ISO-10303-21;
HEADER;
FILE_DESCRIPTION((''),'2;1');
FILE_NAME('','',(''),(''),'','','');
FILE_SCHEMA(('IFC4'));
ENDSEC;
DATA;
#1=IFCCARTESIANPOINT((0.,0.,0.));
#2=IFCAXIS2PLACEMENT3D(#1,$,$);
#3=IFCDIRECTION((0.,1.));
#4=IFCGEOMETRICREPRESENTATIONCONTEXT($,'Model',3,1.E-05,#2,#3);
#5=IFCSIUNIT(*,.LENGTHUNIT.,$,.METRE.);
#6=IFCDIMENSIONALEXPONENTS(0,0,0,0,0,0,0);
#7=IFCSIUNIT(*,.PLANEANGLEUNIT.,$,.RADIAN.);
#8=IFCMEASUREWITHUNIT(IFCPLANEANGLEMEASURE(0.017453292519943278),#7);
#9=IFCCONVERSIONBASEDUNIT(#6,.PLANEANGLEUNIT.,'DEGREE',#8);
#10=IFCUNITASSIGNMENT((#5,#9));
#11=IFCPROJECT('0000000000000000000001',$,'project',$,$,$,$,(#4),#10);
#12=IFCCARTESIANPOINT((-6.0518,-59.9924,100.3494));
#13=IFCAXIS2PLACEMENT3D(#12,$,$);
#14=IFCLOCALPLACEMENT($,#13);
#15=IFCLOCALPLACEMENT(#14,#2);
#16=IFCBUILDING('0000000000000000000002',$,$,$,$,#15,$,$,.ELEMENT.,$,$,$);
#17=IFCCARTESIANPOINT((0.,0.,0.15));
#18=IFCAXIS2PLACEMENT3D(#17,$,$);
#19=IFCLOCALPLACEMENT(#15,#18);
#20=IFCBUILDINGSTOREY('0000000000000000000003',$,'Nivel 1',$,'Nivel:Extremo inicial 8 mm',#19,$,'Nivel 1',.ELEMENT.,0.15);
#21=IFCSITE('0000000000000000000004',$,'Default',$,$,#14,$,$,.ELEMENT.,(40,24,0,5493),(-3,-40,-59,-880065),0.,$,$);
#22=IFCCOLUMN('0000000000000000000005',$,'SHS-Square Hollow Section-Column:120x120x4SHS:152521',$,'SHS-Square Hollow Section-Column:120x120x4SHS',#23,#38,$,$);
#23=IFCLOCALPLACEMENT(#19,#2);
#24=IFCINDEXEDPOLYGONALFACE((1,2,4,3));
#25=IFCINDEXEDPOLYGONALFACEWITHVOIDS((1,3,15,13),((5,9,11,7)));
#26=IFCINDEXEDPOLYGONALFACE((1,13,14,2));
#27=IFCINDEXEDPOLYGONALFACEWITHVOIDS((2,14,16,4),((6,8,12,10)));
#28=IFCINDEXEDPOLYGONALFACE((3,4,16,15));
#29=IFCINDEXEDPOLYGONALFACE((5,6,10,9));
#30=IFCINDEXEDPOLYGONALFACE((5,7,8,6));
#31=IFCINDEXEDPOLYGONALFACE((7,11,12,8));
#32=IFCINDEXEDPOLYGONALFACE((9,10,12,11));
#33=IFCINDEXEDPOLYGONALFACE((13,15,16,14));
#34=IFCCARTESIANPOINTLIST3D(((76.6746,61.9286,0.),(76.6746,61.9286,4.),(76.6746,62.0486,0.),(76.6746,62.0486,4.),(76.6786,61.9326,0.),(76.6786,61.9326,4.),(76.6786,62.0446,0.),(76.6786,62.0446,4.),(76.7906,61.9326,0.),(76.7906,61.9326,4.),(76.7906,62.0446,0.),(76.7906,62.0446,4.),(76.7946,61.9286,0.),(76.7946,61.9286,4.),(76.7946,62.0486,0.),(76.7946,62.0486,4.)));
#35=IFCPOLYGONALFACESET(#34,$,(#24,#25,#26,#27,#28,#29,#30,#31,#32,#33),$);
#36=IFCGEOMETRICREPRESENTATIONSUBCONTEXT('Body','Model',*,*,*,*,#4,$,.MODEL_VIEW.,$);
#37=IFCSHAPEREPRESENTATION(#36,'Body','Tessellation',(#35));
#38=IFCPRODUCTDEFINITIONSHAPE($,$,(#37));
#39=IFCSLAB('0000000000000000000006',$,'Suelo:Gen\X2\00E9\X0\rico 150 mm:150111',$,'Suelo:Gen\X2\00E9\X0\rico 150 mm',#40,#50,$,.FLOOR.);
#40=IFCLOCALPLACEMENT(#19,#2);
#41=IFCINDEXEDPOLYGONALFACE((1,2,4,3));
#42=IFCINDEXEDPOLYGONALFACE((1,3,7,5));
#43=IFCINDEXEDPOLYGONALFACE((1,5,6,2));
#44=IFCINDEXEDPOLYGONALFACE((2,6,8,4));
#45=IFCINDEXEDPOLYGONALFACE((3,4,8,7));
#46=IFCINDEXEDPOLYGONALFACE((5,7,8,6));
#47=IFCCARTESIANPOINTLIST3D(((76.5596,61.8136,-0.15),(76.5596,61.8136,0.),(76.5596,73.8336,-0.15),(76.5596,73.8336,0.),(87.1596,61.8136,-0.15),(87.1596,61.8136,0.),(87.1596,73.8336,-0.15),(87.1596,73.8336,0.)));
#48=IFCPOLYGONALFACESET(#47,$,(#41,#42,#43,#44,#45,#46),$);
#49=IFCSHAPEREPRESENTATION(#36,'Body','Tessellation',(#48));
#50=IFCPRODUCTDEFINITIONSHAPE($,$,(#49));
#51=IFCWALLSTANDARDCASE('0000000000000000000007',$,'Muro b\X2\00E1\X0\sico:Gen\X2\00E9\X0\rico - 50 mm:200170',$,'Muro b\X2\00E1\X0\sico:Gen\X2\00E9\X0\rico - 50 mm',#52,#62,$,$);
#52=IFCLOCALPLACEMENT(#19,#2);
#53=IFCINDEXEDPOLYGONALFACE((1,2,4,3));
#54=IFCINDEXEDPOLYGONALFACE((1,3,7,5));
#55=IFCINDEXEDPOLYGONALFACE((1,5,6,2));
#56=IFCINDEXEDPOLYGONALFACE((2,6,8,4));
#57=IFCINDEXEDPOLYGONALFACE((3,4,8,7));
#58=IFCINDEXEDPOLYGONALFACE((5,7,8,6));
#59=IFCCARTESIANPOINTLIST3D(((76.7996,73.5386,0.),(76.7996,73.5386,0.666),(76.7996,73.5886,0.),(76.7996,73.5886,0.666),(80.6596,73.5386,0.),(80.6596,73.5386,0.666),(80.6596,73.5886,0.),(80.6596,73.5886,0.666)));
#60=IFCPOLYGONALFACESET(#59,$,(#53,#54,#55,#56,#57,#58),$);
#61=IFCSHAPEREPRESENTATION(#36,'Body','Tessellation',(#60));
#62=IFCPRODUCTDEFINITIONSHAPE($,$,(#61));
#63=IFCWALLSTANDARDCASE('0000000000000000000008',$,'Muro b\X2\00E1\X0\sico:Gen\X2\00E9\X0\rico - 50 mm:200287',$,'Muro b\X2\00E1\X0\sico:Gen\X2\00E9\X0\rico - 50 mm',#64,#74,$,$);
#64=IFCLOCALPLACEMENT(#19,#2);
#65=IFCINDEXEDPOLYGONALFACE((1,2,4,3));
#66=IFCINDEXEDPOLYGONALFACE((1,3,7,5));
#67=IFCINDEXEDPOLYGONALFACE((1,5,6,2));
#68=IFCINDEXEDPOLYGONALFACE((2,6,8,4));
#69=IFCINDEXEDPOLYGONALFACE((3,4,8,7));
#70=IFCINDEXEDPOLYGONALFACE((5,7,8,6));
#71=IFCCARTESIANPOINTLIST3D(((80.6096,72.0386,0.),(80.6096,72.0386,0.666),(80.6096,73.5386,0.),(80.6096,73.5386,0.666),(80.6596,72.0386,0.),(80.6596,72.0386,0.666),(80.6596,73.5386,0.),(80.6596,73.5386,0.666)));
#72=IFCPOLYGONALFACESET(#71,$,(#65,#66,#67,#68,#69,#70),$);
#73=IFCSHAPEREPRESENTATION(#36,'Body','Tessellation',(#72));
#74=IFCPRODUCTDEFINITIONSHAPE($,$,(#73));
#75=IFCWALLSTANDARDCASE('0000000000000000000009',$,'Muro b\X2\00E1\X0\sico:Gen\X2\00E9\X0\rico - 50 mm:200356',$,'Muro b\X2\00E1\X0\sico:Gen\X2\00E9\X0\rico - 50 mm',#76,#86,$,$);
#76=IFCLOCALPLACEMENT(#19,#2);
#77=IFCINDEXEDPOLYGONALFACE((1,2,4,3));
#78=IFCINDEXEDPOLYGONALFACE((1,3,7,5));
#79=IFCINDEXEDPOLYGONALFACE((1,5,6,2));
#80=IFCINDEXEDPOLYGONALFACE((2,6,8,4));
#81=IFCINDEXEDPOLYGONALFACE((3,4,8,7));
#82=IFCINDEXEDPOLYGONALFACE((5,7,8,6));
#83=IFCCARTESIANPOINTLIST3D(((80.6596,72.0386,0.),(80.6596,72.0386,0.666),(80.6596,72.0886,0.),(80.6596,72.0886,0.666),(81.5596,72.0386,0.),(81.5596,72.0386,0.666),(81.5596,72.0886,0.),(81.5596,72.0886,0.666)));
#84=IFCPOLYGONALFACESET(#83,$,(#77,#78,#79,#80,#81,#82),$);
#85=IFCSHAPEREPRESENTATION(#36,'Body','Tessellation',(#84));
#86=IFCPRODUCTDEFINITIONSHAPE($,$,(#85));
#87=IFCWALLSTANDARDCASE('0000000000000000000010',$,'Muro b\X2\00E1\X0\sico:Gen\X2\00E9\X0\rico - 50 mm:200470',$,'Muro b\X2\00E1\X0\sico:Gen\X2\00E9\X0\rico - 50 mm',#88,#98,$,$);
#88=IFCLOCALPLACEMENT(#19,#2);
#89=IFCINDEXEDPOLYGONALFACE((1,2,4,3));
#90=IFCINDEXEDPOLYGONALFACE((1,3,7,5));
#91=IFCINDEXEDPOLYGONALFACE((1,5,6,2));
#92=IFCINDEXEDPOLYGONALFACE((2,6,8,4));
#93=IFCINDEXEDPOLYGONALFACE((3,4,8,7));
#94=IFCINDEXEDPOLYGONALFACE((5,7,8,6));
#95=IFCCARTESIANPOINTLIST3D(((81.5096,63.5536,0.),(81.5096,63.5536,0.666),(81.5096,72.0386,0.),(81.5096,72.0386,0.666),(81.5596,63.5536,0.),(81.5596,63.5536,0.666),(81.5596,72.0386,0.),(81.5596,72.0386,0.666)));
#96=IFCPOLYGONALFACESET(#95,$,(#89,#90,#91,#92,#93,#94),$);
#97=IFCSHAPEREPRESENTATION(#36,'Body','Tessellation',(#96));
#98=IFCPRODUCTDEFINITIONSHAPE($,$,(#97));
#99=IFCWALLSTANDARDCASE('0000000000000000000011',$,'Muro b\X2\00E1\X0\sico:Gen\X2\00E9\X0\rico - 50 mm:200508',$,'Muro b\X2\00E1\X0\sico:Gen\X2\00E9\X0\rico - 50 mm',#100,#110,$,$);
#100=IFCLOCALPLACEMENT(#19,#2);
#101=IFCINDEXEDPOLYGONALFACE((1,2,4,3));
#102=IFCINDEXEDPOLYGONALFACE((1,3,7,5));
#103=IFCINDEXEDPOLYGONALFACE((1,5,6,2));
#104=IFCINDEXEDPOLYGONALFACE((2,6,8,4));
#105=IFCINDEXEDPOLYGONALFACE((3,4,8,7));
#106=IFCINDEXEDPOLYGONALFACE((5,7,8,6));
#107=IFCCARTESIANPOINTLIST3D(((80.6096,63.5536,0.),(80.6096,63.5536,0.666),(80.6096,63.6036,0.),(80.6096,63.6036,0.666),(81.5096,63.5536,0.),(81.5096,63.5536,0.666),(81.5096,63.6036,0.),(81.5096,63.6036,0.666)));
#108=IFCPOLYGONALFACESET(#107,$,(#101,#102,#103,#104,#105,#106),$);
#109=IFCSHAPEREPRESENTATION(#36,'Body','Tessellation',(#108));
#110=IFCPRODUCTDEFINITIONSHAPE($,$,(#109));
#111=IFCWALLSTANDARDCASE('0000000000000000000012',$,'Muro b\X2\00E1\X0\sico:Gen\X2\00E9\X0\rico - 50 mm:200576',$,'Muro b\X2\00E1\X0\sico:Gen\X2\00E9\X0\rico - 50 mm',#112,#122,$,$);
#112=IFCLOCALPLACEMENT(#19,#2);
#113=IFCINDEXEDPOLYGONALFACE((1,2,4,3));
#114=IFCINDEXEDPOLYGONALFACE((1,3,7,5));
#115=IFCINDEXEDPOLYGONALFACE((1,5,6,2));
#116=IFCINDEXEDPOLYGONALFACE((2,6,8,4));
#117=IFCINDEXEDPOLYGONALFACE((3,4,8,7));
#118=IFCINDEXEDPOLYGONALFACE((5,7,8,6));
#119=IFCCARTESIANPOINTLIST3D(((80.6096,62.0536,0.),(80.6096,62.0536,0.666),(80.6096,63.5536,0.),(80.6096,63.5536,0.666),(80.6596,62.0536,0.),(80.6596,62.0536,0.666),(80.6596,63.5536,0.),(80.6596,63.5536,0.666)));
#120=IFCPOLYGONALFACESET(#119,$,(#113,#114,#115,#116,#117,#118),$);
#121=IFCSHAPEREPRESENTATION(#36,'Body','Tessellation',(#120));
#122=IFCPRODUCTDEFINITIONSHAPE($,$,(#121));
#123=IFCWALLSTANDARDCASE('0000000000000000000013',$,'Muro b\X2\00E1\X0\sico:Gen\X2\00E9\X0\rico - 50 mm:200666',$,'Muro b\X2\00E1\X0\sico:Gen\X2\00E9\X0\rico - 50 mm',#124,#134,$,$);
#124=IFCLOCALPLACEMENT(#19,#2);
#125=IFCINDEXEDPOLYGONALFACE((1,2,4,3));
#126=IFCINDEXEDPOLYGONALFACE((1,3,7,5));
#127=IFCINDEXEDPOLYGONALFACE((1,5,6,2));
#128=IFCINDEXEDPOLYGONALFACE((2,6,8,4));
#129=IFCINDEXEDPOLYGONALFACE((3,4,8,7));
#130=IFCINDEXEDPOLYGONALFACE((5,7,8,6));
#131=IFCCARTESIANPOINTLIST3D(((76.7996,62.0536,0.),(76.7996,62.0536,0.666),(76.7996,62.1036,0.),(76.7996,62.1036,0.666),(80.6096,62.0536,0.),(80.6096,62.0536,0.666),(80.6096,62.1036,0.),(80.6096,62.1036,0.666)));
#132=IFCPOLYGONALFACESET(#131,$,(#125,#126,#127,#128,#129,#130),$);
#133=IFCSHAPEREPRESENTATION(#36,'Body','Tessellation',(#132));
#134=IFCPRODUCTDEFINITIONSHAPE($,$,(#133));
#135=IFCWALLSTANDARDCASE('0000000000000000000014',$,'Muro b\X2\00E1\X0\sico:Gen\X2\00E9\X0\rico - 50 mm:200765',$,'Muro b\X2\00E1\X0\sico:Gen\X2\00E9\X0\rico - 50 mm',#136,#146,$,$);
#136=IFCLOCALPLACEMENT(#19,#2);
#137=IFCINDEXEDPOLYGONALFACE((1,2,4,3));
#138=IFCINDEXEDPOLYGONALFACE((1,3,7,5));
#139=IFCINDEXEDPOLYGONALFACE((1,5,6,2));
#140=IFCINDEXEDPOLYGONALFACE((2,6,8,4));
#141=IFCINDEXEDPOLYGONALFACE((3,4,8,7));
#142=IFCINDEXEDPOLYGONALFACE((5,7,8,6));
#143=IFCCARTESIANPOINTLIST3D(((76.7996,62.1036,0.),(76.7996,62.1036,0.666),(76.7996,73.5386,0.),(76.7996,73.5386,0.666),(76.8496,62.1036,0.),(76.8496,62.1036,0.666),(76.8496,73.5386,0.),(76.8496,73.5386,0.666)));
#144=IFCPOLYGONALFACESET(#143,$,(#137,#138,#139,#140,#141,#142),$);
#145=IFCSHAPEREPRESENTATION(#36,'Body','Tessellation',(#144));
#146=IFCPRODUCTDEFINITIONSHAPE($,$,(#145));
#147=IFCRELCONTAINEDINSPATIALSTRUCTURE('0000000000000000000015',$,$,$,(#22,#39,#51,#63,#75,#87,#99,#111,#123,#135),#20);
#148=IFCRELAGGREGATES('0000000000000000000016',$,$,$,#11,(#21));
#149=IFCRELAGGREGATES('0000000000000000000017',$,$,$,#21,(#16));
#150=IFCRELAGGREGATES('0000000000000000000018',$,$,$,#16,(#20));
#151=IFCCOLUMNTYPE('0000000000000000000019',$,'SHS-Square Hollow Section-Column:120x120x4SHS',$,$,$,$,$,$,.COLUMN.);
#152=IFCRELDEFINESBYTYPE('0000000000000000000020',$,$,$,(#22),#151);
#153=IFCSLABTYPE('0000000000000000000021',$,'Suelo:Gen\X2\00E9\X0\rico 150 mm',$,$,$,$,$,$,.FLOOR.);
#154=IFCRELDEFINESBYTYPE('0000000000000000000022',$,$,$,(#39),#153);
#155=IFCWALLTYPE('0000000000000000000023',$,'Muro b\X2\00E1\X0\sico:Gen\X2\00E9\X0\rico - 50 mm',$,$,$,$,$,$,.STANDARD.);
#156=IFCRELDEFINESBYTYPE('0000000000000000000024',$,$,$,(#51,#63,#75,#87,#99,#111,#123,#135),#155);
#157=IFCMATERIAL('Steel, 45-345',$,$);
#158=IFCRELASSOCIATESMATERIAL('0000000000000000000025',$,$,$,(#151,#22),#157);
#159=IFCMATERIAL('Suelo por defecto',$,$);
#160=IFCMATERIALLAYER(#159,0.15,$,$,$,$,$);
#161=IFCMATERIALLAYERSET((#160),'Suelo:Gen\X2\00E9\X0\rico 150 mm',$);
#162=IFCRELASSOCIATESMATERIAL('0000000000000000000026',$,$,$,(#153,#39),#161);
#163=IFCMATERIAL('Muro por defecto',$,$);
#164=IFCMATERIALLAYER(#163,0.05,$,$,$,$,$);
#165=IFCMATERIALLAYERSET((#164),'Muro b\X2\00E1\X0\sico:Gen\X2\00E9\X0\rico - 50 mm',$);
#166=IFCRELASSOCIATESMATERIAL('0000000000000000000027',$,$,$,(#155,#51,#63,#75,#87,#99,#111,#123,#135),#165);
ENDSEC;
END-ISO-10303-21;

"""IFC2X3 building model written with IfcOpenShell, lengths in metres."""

from ifc_helpers import new_model, entity, si_unit, converted_unit, direction, frame, frame_2d, origin, place, context, subcontext, project, spatial, polyline, rectangle, outline, extrude, clip, bounded_halfspace, source, transform, mapped, material, layer, layer_set, layer_usage, type_object, type_shapes, element, save


model = new_model("IFC2X3")

# Units and contexts
model_context = context("Model", 3, precision=1e-05, world=origin(), true_north=direction((0.0, 1.0)))
body_context = subcontext(model_context, "Body", "Model", "MODEL_VIEW")
ifc_project = project(units=[si_unit("LENGTHUNIT", "METRE"), converted_unit("PLANEANGLEUNIT", "DEGREE", entity("IfcPlaneAngleMeasure", 0.017453292519943278), si_unit("PLANEANGLEUNIT", "RADIAN"), dimensions=[0, 0, 0, 0, 0, 0, 0])], contexts=[model_context])

# Site, building, storey
site_placement = place(None, frame((-6.0518, -59.9924, 100.3494)))
site = spatial("IfcSite", under=ifc_project, at=site_placement, Name="Default", CompositionType="ELEMENT", RefLatitude=(40, 24, 0, 5493), RefLongitude=(-3, -40, -59, -880065), RefElevation=0.0)
building_placement = place(site_placement, origin())
building = spatial("IfcBuilding", under=site, at=building_placement, CompositionType="ELEMENT")
storey_placement = place(building_placement, frame((0.0, 0.0, 0.15)))
storey = spatial("IfcBuildingStorey", under=building, at=storey_placement, Name="Nivel 1", ObjectType="Nivel:Extremo inicial 8 mm", LongName="Nivel 1", CompositionType="ELEMENT", Elevation=0.15)

# Column
ifc_material_1 = material(Name="Steel, 45-345")
column_type = type_object("IfcColumnType", Name="SHS-Square Hollow Section-Column:120x120x4SHS", PredefinedType="COLUMN", material=ifc_material_1)
shared_shape_1 = source(origin(), body_context, "Body", "SweptSolid", [
    extrude(outline(polyline([(-0.06, -0.06), (0.06, -0.06), (0.06, 0.06), (-0.06, 0.06), (-0.06, -0.06)]), holes=[polyline([(-0.056, -0.056), (-0.056, 0.056), (0.056, 0.056), (0.056, -0.056), (-0.056, -0.056)])]), frame((76.7346, 61.9886, 0.15), z_axis=(0.0, 0.0, 1.0), x_axis=(-1.0, 0.0, 0.0)), (0.0, 0.0, 1.0), 4.0),
])
type_shapes(column_type, [shared_shape_1])
column_placement = place(storey_placement, frame((0.0, 0.0, -0.15)))
element("IfcColumn", 1, at=column_placement, inside=storey, type_object=column_type, material=ifc_material_1, Name="SHS-Square Hollow Section-Column:120x120x4SHS:152521", ObjectType="SHS-Square Hollow Section-Column:120x120x4SHS", context=body_context, shape_type="MappedRepresentation", body=[
    mapped(shared_shape_1, transform((0.0, 0.0, 0.0), scale=1.0)),
])

# Slab
ifc_material_2 = material(Name="Suelo por defecto")
ifc_layer_1 = layer(ifc_material_2, 0.15)
ifc_layer_set_1 = layer_set([ifc_layer_1], Name="Suelo:Genérico 150 mm")
ifc_layer_usage_1 = layer_usage(ifc_layer_set_1, "AXIS3", "POSITIVE", 0.0)
slab_type_1 = type_object("IfcSlabType", Name="Suelo:Genérico 150 mm", PredefinedType="FLOOR", material=ifc_layer_set_1)
slab_1_placement = place(storey_placement, origin())
element("IfcSlab", 2, at=slab_1_placement, inside=storey, type_object=slab_type_1, material=ifc_layer_usage_1, Name="Suelo:Genérico 150 mm:150111", ObjectType="Suelo:Genérico 150 mm", PredefinedType="FLOOR", context=body_context, shape_type="SweptSolid", body=[
    extrude(rectangle(XDim=12.02, YDim=10.6, at=frame_2d((0.0, 0.0), x_axis=(1.0, 0.0))), frame((81.8596, 67.8236, 0.0), z_axis=(0.0, 0.0, -1.0), x_axis=(0.0, 1.0, 0.0)), (0.0, 0.0, 1.0), 0.15),
])

# Walls
ifc_material_3 = material(Name="Muro por defecto")
ifc_layer_2 = layer(ifc_material_3, 0.05)
ifc_layer_set_2 = layer_set([ifc_layer_2], Name="Muro básico:Genérico - 50 mm")
ifc_layer_usage_2 = layer_usage(ifc_layer_set_2, "AXIS2", "POSITIVE", -0.025)
wall_type = type_object("IfcWallType", Name="Muro básico:Genérico - 50 mm", PredefinedType="STANDARD", material=ifc_layer_set_2)
wall_1_placement = place(storey_placement, frame((76.7996, 73.5636, 0.0)))
element("IfcWallStandardCase", 3, at=wall_1_placement, inside=storey, type_object=wall_type, material=ifc_layer_usage_2, Name="Muro básico:Genérico - 50 mm:200170", ObjectType="Muro básico:Genérico - 50 mm", context=body_context, shape_type="Clipping", body=[
    clip(extrude(rectangle(XDim=3.86, YDim=0.05, at=frame_2d((1.93, 0.0), x_axis=(-1.0, 0.0))), origin(), (0.0, 0.0, 1.0), 0.666), bounded_halfspace(frame((0.0, -0.025, 0.666), z_axis=(0.0, 0.0, -1.0), x_axis=(1.0, 0.0, 0.0)), True, frame((0.0, -0.025, 0.666), z_axis=(0.0, 0.0, -1.0), x_axis=(1.0, 0.0, 0.0)), polyline([(0.0, 0.0), (0.0, -0.05), (3.86, -0.05), (3.86, 0.0), (3.81, 0.0), (0.05, 0.0), (0.0, 0.0)]))),
])
ifc_layer_usage_3 = layer_usage(ifc_layer_set_2, "AXIS2", "POSITIVE", -0.025)
wall_2_placement = place(storey_placement, frame((80.6346, 73.5386, 0.0), z_axis=(0.0, 0.0, 1.0), x_axis=(0.0, -1.0, 0.0)))
element("IfcWallStandardCase", 4, at=wall_2_placement, inside=storey, type_object=wall_type, material=ifc_layer_usage_3, Name="Muro básico:Genérico - 50 mm:200287", ObjectType="Muro básico:Genérico - 50 mm", context=body_context, shape_type="Clipping", body=[
    clip(extrude(rectangle(XDim=1.5, YDim=0.05, at=frame_2d((0.75, 0.0), x_axis=(-1.0, 0.0))), origin(), (0.0, 0.0, 1.0), 0.666), bounded_halfspace(frame((0.0, -0.025, 0.666), z_axis=(0.0, 0.0, -1.0), x_axis=(0.0, 1.0, 0.0)), True, frame((0.0, -0.025, 0.666), z_axis=(0.0, 0.0, -1.0), x_axis=(0.0, 1.0, 0.0)), polyline([(0.0, 0.0), (0.05, 0.0), (0.05, 1.45), (0.05, 1.5), (0.0, 1.5), (0.0, 0.0)]))),
])
ifc_layer_usage_4 = layer_usage(ifc_layer_set_2, "AXIS2", "NEGATIVE", 0.025)
wall_3_placement = place(storey_placement, frame((80.6596, 72.0636, 0.0)))
element("IfcWallStandardCase", 5, at=wall_3_placement, inside=storey, type_object=wall_type, material=ifc_layer_usage_4, Name="Muro básico:Genérico - 50 mm:200356", ObjectType="Muro básico:Genérico - 50 mm", context=body_context, shape_type="Clipping", body=[
    clip(extrude(rectangle(XDim=0.9, YDim=0.05, at=frame_2d((0.45, 0.0), x_axis=(-1.0, 0.0))), origin(), (0.0, 0.0, 1.0), 0.666), bounded_halfspace(frame((0.0, -0.025, 0.666), z_axis=(0.0, 0.0, -1.0), x_axis=(1.0, 0.0, 0.0)), True, frame((0.0, -0.025, 0.666), z_axis=(0.0, 0.0, -1.0), x_axis=(1.0, 0.0, 0.0)), polyline([(0.0, 0.0), (0.0, -0.05), (0.9, -0.05), (0.9, 0.0), (0.0, 0.0)]))),
])
ifc_layer_usage_5 = layer_usage(ifc_layer_set_2, "AXIS2", "POSITIVE", -0.025)
wall_4_placement = place(storey_placement, frame((81.5346, 72.0386, 0.0), z_axis=(0.0, 0.0, 1.0), x_axis=(0.0, -1.0, 0.0)))
element("IfcWallStandardCase", 6, at=wall_4_placement, inside=storey, type_object=wall_type, material=ifc_layer_usage_5, Name="Muro básico:Genérico - 50 mm:200470", ObjectType="Muro básico:Genérico - 50 mm", context=body_context, shape_type="Clipping", body=[
    clip(extrude(rectangle(XDim=8.485, YDim=0.05, at=frame_2d((4.2425, 0.0), x_axis=(-1.0, 0.0))), origin(), (0.0, 0.0, 1.0), 0.666), bounded_halfspace(frame((0.0, -0.025, 0.666), z_axis=(0.0, 0.0, -1.0), x_axis=(0.0, 1.0, 0.0)), True, frame((0.0, -0.025, 0.666), z_axis=(0.0, 0.0, -1.0), x_axis=(0.0, 1.0, 0.0)), polyline([(0.0, 0.0), (0.05, 0.0), (0.05, 8.485), (0.0, 8.485), (0.0, 0.0)]))),
])
ifc_layer_usage_6 = layer_usage(ifc_layer_set_2, "AXIS2", "NEGATIVE", 0.025)
wall_5_placement = place(storey_placement, frame((81.5096, 63.5786, 0.0), z_axis=(0.0, 0.0, 1.0), x_axis=(-1.0, 0.0, 0.0)))
element("IfcWallStandardCase", 7, at=wall_5_placement, inside=storey, type_object=wall_type, material=ifc_layer_usage_6, Name="Muro básico:Genérico - 50 mm:200508", ObjectType="Muro básico:Genérico - 50 mm", context=body_context, shape_type="Clipping", body=[
    clip(extrude(rectangle(XDim=0.9, YDim=0.05, at=frame_2d((0.45, 0.0), x_axis=(-1.0, 0.0))), origin(), (0.0, 0.0, 1.0), 0.666), bounded_halfspace(frame((0.0, -0.025, 0.666), z_axis=(0.0, 0.0, -1.0), x_axis=(-1.0, 0.0, 0.0)), True, frame((0.0, -0.025, 0.666), z_axis=(0.0, 0.0, -1.0), x_axis=(-1.0, 0.0, 0.0)), polyline([(0.0, 0.0), (0.0, 0.05), (-0.85, 0.05), (-0.9, 0.05), (-0.9, 0.0), (0.0, 0.0)]))),
])
ifc_layer_usage_7 = layer_usage(ifc_layer_set_2, "AXIS2", "POSITIVE", -0.025)
wall_6_placement = place(storey_placement, frame((80.6346, 63.5536, 0.0), z_axis=(0.0, 0.0, 1.0), x_axis=(0.0, -1.0, 0.0)))
element("IfcWallStandardCase", 8, at=wall_6_placement, inside=storey, type_object=wall_type, material=ifc_layer_usage_7, Name="Muro básico:Genérico - 50 mm:200576", ObjectType="Muro básico:Genérico - 50 mm", context=body_context, shape_type="Clipping", body=[
    clip(extrude(rectangle(XDim=1.5, YDim=0.05, at=frame_2d((0.75, 0.0), x_axis=(-1.0, 0.0))), origin(), (0.0, 0.0, 1.0), 0.666), bounded_halfspace(frame((0.0, -0.025, 0.666), z_axis=(0.0, 0.0, -1.0), x_axis=(0.0, 1.0, 0.0)), True, frame((0.0, -0.025, 0.666), z_axis=(0.0, 0.0, -1.0), x_axis=(0.0, 1.0, 0.0)), polyline([(0.0, 0.0), (0.05, 0.0), (0.05, 1.5), (0.0, 1.5), (0.0, 0.0)]))),
])
ifc_layer_usage_8 = layer_usage(ifc_layer_set_2, "AXIS2", "POSITIVE", -0.025)
wall_7_placement = place(storey_placement, frame((80.6096, 62.0786, 0.0), z_axis=(0.0, 0.0, 1.0), x_axis=(-1.0, 0.0, 0.0)))
element("IfcWallStandardCase", 9, at=wall_7_placement, inside=storey, type_object=wall_type, material=ifc_layer_usage_8, Name="Muro básico:Genérico - 50 mm:200666", ObjectType="Muro básico:Genérico - 50 mm", context=body_context, shape_type="Clipping", body=[
    clip(extrude(rectangle(XDim=3.81, YDim=0.05, at=frame_2d((1.905, 0.0), x_axis=(-1.0, 0.0))), origin(), (0.0, 0.0, 1.0), 0.666), bounded_halfspace(frame((0.0, -0.025, 0.666), z_axis=(0.0, 0.0, -1.0), x_axis=(-1.0, 0.0, 0.0)), True, frame((0.0, -0.025, 0.666), z_axis=(0.0, 0.0, -1.0), x_axis=(-1.0, 0.0, 0.0)), polyline([(0.0, 0.0), (0.0, 0.05), (-3.81, 0.05), (-3.81, 0.0), (-3.76, 0.0), (0.0, 0.0)]))),
])
ifc_layer_usage_9 = layer_usage(ifc_layer_set_2, "AXIS2", "POSITIVE", -0.025)
wall_8_placement = place(storey_placement, frame((76.8246, 62.1036, 0.0), z_axis=(0.0, 0.0, 1.0), x_axis=(0.0, 1.0, 0.0)))
element("IfcWallStandardCase", 10, at=wall_8_placement, inside=storey, type_object=wall_type, material=ifc_layer_usage_9, Name="Muro básico:Genérico - 50 mm:200765", ObjectType="Muro básico:Genérico - 50 mm", context=body_context, shape_type="Clipping", body=[
    clip(extrude(rectangle(XDim=11.435, YDim=0.05, at=frame_2d((5.7175, 0.0), x_axis=(-1.0, 0.0))), origin(), (0.0, 0.0, 1.0), 0.666), bounded_halfspace(frame((0.0, -0.025, 0.666), z_axis=(0.0, 0.0, -1.0), x_axis=(0.0, -1.0, 0.0)), True, frame((0.0, -0.025, 0.666), z_axis=(0.0, 0.0, -1.0), x_axis=(0.0, -1.0, 0.0)), polyline([(0.0, 0.0), (-0.05, 0.0), (-0.05, -11.435), (0.0, -11.435), (0.0, 0.0)]))),
])

save(model, "model.ifc")
